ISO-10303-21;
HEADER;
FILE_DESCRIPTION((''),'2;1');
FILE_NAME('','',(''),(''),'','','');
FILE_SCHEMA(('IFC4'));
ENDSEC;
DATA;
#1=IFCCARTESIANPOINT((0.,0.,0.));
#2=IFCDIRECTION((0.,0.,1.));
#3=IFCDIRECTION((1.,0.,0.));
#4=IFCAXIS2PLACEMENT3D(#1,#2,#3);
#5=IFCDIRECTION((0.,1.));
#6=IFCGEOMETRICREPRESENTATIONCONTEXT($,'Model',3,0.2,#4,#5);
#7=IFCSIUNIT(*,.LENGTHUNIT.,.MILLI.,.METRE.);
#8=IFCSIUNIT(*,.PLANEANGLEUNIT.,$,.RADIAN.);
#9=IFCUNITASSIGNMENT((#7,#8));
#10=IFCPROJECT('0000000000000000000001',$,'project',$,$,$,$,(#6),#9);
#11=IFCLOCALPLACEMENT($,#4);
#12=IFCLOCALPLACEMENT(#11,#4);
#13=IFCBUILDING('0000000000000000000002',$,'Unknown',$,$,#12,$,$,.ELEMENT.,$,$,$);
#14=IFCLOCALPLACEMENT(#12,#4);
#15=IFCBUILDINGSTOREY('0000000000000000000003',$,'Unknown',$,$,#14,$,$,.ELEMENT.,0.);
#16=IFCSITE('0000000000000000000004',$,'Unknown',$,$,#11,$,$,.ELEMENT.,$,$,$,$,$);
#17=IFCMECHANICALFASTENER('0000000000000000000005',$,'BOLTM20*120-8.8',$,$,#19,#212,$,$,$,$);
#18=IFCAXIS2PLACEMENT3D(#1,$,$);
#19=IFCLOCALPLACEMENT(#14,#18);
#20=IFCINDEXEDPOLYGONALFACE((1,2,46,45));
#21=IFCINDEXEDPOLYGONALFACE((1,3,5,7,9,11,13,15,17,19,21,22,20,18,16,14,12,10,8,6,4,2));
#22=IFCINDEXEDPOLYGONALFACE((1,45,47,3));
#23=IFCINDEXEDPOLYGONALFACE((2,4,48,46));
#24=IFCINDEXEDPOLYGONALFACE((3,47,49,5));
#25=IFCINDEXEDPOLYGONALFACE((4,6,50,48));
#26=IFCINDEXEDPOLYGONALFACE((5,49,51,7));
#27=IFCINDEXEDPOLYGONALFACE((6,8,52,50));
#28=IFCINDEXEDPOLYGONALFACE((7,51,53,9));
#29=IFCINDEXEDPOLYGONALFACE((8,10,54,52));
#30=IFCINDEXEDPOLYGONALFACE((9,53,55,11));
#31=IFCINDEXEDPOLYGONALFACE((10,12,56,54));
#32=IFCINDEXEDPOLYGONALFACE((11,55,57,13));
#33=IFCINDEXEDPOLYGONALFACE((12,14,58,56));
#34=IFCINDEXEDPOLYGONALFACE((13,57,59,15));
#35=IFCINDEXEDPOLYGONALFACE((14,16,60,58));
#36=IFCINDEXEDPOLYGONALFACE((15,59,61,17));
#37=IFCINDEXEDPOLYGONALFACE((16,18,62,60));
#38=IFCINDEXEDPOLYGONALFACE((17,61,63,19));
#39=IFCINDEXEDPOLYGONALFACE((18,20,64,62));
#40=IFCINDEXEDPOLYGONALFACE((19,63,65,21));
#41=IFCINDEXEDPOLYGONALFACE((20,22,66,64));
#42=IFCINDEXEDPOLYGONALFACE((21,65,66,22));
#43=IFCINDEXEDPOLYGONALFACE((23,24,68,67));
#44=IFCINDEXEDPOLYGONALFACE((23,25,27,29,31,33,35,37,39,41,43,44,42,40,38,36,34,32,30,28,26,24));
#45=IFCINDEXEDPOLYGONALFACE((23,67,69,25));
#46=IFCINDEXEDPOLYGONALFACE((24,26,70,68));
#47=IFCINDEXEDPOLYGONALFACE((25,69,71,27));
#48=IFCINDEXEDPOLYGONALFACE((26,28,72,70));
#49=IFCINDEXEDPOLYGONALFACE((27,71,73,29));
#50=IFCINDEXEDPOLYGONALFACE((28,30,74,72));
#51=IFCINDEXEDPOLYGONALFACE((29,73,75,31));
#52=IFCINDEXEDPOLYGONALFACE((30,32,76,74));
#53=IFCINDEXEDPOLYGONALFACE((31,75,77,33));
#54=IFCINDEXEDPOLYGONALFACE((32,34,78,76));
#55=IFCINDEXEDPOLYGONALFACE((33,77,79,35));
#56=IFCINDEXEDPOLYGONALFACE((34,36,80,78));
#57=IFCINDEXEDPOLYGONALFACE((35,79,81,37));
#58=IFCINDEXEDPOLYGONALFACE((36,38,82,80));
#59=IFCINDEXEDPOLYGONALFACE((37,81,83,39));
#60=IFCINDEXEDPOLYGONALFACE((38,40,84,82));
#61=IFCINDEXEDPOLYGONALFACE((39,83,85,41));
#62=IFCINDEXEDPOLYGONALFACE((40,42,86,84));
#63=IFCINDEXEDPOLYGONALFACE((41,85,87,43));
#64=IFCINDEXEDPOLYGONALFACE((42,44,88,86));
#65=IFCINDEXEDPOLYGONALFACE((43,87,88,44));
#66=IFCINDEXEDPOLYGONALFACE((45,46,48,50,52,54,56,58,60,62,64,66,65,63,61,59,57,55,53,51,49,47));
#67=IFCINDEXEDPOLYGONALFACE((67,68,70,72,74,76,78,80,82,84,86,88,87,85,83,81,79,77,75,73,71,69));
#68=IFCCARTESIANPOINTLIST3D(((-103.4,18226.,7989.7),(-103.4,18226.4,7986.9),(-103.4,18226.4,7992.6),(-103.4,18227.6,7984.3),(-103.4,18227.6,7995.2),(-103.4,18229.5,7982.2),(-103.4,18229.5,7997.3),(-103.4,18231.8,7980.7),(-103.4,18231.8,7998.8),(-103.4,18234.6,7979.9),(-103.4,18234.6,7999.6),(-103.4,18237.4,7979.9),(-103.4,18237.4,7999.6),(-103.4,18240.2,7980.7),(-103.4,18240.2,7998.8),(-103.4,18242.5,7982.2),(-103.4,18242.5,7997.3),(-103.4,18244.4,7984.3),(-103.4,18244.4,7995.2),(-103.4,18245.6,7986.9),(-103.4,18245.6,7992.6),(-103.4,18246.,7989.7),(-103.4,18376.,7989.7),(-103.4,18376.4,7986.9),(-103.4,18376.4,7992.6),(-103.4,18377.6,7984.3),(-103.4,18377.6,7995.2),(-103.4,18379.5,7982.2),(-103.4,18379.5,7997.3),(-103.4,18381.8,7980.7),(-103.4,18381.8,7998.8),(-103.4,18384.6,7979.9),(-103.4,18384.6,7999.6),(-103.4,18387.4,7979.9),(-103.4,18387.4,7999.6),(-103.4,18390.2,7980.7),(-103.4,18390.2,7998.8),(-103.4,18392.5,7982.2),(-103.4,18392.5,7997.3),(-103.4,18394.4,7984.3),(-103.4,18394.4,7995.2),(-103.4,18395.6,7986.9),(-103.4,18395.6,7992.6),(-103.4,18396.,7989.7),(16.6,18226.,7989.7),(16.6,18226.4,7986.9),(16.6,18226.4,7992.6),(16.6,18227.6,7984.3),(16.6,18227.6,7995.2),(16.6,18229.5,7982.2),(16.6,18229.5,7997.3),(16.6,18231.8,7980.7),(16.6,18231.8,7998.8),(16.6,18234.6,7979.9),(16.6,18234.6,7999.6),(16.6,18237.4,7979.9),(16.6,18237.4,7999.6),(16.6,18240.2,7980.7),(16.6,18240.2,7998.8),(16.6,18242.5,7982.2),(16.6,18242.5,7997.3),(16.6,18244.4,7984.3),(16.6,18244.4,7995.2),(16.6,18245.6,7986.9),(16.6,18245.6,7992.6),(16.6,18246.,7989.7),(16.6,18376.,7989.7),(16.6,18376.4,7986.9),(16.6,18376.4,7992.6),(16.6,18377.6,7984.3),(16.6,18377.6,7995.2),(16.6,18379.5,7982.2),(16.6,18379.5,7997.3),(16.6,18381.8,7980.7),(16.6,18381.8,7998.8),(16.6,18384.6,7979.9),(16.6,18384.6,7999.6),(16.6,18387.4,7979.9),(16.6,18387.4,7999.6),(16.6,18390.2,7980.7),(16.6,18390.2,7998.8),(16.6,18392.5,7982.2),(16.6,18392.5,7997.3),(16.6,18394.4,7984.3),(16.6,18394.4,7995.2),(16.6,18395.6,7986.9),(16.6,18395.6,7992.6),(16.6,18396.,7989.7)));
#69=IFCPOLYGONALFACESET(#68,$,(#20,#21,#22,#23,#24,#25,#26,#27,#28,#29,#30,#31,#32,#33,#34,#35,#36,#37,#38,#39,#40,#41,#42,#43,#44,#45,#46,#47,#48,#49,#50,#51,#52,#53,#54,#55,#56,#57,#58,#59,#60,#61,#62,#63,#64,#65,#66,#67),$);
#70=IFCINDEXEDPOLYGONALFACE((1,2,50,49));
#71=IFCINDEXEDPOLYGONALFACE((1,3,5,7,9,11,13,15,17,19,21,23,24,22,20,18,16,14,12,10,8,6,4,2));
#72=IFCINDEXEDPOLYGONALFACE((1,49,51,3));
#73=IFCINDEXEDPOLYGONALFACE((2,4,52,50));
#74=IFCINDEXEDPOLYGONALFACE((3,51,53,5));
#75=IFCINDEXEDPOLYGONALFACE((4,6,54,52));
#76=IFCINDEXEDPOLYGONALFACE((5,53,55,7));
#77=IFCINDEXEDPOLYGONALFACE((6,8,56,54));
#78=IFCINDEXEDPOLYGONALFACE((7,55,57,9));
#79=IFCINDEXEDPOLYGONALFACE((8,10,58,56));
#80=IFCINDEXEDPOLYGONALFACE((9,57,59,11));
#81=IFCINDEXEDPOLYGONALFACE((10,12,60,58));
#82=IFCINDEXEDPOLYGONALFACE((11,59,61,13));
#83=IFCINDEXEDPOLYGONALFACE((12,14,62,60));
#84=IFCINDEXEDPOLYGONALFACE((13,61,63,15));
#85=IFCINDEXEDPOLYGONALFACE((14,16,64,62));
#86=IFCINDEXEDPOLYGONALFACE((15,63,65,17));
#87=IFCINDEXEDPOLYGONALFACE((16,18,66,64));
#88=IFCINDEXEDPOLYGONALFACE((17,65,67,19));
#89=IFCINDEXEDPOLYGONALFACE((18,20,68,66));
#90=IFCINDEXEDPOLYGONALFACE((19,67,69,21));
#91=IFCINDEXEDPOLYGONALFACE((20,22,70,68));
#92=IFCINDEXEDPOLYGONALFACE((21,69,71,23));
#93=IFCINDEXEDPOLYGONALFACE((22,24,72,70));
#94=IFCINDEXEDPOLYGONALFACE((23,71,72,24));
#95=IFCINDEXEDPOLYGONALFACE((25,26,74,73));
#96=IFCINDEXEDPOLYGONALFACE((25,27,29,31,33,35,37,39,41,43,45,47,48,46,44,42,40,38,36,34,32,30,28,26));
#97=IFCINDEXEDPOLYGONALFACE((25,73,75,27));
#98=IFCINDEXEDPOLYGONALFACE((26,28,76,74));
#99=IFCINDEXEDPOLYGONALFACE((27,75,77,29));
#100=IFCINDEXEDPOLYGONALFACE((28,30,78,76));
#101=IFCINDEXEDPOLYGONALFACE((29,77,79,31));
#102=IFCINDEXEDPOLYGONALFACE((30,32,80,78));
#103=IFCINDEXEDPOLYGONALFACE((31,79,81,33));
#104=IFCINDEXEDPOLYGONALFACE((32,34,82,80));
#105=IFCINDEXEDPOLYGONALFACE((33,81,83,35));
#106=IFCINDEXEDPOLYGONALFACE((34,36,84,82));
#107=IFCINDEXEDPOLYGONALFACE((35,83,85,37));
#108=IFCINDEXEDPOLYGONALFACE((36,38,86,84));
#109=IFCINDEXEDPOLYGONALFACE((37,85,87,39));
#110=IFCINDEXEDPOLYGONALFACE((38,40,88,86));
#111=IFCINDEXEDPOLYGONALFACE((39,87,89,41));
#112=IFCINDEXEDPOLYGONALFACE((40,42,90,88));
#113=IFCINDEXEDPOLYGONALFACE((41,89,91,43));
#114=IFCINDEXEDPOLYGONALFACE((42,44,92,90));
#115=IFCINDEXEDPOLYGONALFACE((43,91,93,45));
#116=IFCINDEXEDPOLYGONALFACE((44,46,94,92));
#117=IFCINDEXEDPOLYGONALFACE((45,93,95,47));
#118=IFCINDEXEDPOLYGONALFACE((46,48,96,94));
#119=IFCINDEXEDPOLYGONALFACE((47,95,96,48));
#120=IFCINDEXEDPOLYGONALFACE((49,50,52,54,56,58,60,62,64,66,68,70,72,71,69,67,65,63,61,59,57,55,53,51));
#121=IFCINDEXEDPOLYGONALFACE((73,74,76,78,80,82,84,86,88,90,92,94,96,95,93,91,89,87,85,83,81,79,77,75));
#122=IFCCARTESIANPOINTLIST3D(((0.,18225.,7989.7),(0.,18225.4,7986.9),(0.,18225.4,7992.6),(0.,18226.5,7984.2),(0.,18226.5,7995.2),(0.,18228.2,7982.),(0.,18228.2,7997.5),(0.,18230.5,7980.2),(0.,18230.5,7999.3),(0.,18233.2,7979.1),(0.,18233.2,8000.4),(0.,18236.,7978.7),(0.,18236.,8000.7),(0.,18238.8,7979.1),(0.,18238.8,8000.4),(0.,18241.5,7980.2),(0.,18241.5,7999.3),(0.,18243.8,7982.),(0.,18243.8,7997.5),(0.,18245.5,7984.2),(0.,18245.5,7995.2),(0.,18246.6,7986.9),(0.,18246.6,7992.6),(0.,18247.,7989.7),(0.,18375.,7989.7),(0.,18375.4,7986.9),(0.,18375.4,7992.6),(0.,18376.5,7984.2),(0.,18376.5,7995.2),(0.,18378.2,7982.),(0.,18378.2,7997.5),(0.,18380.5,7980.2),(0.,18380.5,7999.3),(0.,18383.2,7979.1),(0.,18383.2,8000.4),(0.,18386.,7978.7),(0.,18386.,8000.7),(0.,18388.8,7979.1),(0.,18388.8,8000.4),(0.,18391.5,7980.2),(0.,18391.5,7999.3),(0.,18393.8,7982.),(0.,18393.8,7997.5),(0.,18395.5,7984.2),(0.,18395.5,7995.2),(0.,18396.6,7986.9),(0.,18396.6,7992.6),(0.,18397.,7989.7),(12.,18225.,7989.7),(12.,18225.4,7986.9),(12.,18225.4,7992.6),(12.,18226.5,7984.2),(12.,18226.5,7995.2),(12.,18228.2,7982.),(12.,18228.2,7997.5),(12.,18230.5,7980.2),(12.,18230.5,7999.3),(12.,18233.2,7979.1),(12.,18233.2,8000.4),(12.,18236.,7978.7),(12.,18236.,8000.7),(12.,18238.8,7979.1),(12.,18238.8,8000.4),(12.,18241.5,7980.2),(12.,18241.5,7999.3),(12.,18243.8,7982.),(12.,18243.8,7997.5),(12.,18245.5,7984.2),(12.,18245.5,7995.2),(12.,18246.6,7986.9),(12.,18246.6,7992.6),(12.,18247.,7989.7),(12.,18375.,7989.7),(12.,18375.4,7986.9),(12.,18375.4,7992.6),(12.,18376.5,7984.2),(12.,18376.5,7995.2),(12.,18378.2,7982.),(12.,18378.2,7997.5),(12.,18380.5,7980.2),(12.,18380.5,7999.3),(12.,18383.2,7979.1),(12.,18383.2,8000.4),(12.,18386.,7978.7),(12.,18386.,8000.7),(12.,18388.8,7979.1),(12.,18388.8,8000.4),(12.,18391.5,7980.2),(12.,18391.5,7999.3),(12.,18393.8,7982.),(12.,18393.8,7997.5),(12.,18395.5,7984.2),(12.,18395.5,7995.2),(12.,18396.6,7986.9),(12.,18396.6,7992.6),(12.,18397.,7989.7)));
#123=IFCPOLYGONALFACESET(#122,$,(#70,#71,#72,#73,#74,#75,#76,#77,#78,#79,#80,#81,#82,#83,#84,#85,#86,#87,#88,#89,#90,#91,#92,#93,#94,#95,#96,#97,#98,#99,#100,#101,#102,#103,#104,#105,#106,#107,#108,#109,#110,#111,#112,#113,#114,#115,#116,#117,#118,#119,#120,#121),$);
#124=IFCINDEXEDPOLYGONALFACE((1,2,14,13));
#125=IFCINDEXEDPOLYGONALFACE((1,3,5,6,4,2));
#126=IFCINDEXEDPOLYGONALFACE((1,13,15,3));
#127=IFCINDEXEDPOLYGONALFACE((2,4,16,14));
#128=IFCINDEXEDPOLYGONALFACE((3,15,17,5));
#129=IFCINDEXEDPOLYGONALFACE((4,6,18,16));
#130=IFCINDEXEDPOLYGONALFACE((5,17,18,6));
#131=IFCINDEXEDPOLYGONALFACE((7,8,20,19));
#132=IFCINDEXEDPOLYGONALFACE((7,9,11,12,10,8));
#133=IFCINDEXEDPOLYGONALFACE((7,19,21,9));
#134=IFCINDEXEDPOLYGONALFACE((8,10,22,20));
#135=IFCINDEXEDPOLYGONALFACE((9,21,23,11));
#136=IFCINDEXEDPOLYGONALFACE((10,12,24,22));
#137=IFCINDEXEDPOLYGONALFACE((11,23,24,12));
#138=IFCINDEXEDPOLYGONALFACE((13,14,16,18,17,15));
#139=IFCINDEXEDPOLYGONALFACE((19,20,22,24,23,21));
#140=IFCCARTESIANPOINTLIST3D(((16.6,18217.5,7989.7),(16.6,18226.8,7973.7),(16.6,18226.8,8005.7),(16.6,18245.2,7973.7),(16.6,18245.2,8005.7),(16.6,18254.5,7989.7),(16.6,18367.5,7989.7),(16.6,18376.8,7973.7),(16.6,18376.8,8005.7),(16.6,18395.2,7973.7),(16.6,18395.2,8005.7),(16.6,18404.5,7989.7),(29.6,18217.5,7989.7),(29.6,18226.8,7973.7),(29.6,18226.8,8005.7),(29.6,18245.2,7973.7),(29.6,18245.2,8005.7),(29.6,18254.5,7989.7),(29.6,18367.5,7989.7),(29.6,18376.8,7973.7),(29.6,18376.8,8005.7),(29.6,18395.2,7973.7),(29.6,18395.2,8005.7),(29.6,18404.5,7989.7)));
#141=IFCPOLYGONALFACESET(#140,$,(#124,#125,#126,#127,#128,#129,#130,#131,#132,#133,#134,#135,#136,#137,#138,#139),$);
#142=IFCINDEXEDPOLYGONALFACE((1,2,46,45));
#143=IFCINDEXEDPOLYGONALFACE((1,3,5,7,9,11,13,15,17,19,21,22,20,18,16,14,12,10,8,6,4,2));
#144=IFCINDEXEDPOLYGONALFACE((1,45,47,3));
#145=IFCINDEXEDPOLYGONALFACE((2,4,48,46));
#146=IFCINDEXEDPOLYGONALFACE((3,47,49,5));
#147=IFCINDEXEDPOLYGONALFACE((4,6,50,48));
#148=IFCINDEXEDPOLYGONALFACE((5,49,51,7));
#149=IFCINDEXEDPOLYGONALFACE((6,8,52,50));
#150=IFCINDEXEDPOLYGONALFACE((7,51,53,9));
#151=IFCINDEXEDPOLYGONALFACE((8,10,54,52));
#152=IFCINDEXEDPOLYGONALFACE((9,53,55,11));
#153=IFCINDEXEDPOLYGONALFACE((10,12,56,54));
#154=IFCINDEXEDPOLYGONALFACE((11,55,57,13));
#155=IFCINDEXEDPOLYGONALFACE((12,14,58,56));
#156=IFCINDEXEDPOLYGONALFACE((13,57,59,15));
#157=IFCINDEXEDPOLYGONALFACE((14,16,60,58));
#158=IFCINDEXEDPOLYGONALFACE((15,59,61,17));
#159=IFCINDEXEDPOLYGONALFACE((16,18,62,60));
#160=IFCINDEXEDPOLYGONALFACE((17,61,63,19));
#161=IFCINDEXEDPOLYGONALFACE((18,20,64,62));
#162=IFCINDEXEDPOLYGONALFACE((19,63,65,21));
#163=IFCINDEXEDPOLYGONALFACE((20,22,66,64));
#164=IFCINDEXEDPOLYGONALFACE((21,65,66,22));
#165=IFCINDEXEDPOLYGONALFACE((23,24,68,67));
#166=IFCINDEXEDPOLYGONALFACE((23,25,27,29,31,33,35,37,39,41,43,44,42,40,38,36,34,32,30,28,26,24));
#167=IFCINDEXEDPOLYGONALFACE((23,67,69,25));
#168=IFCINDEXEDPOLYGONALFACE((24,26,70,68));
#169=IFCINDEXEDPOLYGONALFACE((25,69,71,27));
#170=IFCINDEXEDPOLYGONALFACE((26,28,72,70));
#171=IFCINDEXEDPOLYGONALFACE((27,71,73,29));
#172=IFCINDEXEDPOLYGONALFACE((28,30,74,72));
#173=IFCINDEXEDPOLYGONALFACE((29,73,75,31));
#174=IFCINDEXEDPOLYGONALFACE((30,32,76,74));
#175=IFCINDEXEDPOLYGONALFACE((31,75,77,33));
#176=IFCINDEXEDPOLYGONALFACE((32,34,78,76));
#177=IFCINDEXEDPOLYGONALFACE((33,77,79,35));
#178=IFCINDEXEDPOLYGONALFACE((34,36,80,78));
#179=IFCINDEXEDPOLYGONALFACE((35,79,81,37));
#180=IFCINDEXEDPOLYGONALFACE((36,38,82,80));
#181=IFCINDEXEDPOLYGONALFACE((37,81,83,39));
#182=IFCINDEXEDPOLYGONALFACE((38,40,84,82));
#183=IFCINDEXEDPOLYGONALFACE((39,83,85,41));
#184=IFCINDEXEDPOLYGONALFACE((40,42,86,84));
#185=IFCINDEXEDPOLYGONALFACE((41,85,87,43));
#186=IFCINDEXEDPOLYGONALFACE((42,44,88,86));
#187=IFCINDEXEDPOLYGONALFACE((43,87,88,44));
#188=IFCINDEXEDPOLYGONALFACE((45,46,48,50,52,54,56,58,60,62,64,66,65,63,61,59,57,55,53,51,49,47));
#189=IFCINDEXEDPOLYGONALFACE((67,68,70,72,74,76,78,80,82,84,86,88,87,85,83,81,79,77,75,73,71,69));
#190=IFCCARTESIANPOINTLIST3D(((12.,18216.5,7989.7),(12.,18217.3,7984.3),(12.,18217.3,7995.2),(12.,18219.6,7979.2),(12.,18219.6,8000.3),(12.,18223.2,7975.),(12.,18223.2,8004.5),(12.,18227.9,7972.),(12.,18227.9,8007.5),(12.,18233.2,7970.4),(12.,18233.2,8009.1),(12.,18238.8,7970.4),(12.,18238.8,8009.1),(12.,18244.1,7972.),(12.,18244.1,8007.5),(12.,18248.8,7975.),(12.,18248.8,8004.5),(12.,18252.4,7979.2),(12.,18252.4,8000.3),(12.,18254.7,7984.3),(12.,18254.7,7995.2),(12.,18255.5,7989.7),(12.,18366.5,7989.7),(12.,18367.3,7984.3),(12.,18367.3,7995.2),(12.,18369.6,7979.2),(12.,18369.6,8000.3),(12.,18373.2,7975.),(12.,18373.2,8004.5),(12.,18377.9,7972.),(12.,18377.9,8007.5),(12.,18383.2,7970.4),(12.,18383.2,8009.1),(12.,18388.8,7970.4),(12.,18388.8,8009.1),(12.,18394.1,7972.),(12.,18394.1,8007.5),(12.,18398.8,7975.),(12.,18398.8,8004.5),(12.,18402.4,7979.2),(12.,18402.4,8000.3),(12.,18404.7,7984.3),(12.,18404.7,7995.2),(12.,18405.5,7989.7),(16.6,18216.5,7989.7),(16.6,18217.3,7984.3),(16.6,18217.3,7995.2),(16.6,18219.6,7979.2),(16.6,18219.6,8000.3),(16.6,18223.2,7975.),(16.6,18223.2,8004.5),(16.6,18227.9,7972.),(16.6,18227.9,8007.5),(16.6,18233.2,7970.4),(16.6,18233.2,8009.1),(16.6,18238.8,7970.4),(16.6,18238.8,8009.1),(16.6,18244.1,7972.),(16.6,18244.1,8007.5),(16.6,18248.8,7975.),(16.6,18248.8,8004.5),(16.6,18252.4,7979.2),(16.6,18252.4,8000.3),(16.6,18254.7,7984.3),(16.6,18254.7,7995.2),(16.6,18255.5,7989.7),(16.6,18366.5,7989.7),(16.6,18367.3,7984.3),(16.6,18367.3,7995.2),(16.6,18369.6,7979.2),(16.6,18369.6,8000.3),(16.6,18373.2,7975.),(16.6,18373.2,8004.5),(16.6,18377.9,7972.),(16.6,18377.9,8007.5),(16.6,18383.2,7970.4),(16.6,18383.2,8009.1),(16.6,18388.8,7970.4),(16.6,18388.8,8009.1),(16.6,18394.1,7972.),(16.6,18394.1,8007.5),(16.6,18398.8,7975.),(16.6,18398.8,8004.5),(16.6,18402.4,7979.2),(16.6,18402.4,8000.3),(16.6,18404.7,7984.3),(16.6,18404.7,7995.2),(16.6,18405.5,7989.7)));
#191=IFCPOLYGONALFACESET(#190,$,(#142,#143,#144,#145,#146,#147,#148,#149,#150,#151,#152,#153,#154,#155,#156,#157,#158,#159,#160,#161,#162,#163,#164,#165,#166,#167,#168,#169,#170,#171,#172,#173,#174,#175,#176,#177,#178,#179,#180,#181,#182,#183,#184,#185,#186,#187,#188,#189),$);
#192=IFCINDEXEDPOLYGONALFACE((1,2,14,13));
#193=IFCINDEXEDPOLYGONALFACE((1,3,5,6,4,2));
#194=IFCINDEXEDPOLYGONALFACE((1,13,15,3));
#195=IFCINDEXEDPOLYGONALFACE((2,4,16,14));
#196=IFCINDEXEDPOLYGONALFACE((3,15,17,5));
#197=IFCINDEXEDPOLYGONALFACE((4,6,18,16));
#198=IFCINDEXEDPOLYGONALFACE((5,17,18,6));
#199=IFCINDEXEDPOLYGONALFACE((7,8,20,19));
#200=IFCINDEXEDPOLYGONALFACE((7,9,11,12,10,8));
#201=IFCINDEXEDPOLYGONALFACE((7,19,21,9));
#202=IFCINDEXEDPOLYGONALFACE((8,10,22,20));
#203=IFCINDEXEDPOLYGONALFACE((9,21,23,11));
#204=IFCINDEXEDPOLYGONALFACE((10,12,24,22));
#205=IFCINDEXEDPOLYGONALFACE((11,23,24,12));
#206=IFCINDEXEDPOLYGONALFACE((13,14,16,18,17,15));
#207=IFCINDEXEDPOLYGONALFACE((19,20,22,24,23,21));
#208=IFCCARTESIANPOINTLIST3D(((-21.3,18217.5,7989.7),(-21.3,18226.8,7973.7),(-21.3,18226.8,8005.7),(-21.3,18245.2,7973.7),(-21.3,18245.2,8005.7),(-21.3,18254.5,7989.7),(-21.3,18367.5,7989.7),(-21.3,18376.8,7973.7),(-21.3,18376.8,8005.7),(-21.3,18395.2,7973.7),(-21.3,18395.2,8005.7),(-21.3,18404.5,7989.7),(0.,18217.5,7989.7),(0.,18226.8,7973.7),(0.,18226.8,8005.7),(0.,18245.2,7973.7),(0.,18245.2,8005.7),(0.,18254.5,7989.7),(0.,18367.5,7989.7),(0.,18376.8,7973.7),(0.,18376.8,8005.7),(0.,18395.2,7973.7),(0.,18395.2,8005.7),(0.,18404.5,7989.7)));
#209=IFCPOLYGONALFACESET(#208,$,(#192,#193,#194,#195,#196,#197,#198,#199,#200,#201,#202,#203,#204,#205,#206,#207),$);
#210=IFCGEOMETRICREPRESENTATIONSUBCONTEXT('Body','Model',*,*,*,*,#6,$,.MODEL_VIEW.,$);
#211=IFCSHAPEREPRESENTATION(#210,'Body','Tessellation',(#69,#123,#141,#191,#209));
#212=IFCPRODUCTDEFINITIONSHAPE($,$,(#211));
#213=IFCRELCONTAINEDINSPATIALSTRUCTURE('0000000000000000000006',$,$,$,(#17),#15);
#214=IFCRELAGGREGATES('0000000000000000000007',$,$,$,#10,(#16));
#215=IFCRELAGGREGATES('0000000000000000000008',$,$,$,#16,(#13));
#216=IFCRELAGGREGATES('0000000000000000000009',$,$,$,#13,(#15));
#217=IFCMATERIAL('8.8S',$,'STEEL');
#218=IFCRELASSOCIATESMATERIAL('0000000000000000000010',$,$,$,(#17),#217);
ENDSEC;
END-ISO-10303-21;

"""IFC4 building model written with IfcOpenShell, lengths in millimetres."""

from ifc_helpers import new_model, si_unit, direction, frame, origin_with_axes, place, context, subcontext, project, spatial, line, arc, indexed_curve, outline, extrude, source, transform, mapped, material, element, save


model = new_model("IFC4")

# Units and contexts
model_context = context("Model", 3, precision=0.2, world=origin_with_axes(), true_north=direction((0.0, 1.0)))
body_context = subcontext(model_context, "Body", "Model", "MODEL_VIEW")
ifc_project = project(units=[si_unit("LENGTHUNIT", "METRE", prefix="MILLI"), si_unit("PLANEANGLEUNIT", "RADIAN")], contexts=[model_context])

# Site, building, storey
site_placement = place(None, origin_with_axes())
site = spatial("IfcSite", under=ifc_project, at=site_placement, Name="Unknown", CompositionType="ELEMENT")
building_placement = place(site_placement, origin_with_axes())
building = spatial("IfcBuilding", under=site, at=building_placement, Name="Unknown", CompositionType="ELEMENT")
storey_placement = place(building_placement, origin_with_axes())
storey = spatial("IfcBuildingStorey", under=building, at=storey_placement, Name="Unknown", CompositionType="ELEMENT", Elevation=0.0)

# Mechanical fastener
ifc_material_1 = material(Name="8.8S", Category="STEEL")
shared_shape_1 = source(origin_with_axes(), body_context, "Body", "SweptSolid", [
    extrude(outline(indexed_curve([(10.0, 0.0), (0.0, 10.0), (-10.0, 0.0), (0.0, -10.0)], segments=[arc(1, 2, 3), arc(3, 4, 1)])), frame((0.0, 0.0, 4.6), z_axis=(0.0, 0.0, -1.0), x_axis=(0.0, 1.0, 0.0)), (0.0, 0.0, 1.0), 120.0),
    extrude(outline(indexed_curve([(0.0, 11.0), (7.8, 7.8), (11.0, 0.0), (7.8, -7.8), (0.0, -11.0), (-1.0, -11.0), (-11.0, 0.0), (-7.8, 7.8)], segments=[arc(1, 2, 3), arc(3, 4, 5), arc(5, 6, 7), arc(7, 8, 1)])), frame((0.0, 0.0, 0.0), z_axis=(0.0, 0.0, -1.0), x_axis=(0.0, 1.0, 0.0)), (0.0, 0.0, 1.0), 12.0),
    extrude(outline(indexed_curve([(18.5, 0.0), (9.2, 16.0), (-9.2, 16.0), (-18.5, 0.0), (-9.2, -16.0), (9.2, -16.0)], segments=[line(1, 2, 3, 4, 5, 6, 1)])), frame((0.0, 0.0, 17.6), z_axis=(0.0, 0.0, -1.0), x_axis=(0.0, 1.0, 0.0)), (0.0, 0.0, 1.0), 13.0),
    extrude(outline(indexed_curve([(19.5, 0.0), (0.0, 19.5), (-19.5, 0.0), (0.0, -19.5)], segments=[arc(1, 2, 3), arc(3, 4, 1)])), frame((0.0, 0.0, 4.6), z_axis=(0.0, 0.0, -1.0), x_axis=(0.0, 1.0, 0.0)), (0.0, 0.0, 1.0), 4.6),
    extrude(outline(indexed_curve([(18.5, 0.0), (9.2, 16.0), (-9.2, 16.0), (-18.5, 0.0), (-9.2, -16.0), (9.2, -16.0)], segments=[line(1, 2, 3, 4, 5, 6, 1)])), frame((0.0, 0.0, -12.0), z_axis=(0.0, 0.0, -1.0), x_axis=(0.0, 1.0, 0.0)), (0.0, 0.0, 1.0), 21.3),
])
mechanical_fastener_1_placement = place(storey_placement, frame((12.0, 18311.0, 7989.7), z_axis=(1.0, 0.0, 0.0), x_axis=(0.0, 0.0, -1.0)))
element("IfcMechanicalFastener", 1, at=mechanical_fastener_1_placement, inside=storey, material=ifc_material_1, Name="BOLTM20*120-8.8", context=body_context, shape_type="MappedRepresentation", body=[
    mapped(shared_shape_1, transform((0.0, -75.0, 0.0))),
    mapped(shared_shape_1, transform((0.0, 75.0, 0.0))),
])

save(model, "model.ifc")
